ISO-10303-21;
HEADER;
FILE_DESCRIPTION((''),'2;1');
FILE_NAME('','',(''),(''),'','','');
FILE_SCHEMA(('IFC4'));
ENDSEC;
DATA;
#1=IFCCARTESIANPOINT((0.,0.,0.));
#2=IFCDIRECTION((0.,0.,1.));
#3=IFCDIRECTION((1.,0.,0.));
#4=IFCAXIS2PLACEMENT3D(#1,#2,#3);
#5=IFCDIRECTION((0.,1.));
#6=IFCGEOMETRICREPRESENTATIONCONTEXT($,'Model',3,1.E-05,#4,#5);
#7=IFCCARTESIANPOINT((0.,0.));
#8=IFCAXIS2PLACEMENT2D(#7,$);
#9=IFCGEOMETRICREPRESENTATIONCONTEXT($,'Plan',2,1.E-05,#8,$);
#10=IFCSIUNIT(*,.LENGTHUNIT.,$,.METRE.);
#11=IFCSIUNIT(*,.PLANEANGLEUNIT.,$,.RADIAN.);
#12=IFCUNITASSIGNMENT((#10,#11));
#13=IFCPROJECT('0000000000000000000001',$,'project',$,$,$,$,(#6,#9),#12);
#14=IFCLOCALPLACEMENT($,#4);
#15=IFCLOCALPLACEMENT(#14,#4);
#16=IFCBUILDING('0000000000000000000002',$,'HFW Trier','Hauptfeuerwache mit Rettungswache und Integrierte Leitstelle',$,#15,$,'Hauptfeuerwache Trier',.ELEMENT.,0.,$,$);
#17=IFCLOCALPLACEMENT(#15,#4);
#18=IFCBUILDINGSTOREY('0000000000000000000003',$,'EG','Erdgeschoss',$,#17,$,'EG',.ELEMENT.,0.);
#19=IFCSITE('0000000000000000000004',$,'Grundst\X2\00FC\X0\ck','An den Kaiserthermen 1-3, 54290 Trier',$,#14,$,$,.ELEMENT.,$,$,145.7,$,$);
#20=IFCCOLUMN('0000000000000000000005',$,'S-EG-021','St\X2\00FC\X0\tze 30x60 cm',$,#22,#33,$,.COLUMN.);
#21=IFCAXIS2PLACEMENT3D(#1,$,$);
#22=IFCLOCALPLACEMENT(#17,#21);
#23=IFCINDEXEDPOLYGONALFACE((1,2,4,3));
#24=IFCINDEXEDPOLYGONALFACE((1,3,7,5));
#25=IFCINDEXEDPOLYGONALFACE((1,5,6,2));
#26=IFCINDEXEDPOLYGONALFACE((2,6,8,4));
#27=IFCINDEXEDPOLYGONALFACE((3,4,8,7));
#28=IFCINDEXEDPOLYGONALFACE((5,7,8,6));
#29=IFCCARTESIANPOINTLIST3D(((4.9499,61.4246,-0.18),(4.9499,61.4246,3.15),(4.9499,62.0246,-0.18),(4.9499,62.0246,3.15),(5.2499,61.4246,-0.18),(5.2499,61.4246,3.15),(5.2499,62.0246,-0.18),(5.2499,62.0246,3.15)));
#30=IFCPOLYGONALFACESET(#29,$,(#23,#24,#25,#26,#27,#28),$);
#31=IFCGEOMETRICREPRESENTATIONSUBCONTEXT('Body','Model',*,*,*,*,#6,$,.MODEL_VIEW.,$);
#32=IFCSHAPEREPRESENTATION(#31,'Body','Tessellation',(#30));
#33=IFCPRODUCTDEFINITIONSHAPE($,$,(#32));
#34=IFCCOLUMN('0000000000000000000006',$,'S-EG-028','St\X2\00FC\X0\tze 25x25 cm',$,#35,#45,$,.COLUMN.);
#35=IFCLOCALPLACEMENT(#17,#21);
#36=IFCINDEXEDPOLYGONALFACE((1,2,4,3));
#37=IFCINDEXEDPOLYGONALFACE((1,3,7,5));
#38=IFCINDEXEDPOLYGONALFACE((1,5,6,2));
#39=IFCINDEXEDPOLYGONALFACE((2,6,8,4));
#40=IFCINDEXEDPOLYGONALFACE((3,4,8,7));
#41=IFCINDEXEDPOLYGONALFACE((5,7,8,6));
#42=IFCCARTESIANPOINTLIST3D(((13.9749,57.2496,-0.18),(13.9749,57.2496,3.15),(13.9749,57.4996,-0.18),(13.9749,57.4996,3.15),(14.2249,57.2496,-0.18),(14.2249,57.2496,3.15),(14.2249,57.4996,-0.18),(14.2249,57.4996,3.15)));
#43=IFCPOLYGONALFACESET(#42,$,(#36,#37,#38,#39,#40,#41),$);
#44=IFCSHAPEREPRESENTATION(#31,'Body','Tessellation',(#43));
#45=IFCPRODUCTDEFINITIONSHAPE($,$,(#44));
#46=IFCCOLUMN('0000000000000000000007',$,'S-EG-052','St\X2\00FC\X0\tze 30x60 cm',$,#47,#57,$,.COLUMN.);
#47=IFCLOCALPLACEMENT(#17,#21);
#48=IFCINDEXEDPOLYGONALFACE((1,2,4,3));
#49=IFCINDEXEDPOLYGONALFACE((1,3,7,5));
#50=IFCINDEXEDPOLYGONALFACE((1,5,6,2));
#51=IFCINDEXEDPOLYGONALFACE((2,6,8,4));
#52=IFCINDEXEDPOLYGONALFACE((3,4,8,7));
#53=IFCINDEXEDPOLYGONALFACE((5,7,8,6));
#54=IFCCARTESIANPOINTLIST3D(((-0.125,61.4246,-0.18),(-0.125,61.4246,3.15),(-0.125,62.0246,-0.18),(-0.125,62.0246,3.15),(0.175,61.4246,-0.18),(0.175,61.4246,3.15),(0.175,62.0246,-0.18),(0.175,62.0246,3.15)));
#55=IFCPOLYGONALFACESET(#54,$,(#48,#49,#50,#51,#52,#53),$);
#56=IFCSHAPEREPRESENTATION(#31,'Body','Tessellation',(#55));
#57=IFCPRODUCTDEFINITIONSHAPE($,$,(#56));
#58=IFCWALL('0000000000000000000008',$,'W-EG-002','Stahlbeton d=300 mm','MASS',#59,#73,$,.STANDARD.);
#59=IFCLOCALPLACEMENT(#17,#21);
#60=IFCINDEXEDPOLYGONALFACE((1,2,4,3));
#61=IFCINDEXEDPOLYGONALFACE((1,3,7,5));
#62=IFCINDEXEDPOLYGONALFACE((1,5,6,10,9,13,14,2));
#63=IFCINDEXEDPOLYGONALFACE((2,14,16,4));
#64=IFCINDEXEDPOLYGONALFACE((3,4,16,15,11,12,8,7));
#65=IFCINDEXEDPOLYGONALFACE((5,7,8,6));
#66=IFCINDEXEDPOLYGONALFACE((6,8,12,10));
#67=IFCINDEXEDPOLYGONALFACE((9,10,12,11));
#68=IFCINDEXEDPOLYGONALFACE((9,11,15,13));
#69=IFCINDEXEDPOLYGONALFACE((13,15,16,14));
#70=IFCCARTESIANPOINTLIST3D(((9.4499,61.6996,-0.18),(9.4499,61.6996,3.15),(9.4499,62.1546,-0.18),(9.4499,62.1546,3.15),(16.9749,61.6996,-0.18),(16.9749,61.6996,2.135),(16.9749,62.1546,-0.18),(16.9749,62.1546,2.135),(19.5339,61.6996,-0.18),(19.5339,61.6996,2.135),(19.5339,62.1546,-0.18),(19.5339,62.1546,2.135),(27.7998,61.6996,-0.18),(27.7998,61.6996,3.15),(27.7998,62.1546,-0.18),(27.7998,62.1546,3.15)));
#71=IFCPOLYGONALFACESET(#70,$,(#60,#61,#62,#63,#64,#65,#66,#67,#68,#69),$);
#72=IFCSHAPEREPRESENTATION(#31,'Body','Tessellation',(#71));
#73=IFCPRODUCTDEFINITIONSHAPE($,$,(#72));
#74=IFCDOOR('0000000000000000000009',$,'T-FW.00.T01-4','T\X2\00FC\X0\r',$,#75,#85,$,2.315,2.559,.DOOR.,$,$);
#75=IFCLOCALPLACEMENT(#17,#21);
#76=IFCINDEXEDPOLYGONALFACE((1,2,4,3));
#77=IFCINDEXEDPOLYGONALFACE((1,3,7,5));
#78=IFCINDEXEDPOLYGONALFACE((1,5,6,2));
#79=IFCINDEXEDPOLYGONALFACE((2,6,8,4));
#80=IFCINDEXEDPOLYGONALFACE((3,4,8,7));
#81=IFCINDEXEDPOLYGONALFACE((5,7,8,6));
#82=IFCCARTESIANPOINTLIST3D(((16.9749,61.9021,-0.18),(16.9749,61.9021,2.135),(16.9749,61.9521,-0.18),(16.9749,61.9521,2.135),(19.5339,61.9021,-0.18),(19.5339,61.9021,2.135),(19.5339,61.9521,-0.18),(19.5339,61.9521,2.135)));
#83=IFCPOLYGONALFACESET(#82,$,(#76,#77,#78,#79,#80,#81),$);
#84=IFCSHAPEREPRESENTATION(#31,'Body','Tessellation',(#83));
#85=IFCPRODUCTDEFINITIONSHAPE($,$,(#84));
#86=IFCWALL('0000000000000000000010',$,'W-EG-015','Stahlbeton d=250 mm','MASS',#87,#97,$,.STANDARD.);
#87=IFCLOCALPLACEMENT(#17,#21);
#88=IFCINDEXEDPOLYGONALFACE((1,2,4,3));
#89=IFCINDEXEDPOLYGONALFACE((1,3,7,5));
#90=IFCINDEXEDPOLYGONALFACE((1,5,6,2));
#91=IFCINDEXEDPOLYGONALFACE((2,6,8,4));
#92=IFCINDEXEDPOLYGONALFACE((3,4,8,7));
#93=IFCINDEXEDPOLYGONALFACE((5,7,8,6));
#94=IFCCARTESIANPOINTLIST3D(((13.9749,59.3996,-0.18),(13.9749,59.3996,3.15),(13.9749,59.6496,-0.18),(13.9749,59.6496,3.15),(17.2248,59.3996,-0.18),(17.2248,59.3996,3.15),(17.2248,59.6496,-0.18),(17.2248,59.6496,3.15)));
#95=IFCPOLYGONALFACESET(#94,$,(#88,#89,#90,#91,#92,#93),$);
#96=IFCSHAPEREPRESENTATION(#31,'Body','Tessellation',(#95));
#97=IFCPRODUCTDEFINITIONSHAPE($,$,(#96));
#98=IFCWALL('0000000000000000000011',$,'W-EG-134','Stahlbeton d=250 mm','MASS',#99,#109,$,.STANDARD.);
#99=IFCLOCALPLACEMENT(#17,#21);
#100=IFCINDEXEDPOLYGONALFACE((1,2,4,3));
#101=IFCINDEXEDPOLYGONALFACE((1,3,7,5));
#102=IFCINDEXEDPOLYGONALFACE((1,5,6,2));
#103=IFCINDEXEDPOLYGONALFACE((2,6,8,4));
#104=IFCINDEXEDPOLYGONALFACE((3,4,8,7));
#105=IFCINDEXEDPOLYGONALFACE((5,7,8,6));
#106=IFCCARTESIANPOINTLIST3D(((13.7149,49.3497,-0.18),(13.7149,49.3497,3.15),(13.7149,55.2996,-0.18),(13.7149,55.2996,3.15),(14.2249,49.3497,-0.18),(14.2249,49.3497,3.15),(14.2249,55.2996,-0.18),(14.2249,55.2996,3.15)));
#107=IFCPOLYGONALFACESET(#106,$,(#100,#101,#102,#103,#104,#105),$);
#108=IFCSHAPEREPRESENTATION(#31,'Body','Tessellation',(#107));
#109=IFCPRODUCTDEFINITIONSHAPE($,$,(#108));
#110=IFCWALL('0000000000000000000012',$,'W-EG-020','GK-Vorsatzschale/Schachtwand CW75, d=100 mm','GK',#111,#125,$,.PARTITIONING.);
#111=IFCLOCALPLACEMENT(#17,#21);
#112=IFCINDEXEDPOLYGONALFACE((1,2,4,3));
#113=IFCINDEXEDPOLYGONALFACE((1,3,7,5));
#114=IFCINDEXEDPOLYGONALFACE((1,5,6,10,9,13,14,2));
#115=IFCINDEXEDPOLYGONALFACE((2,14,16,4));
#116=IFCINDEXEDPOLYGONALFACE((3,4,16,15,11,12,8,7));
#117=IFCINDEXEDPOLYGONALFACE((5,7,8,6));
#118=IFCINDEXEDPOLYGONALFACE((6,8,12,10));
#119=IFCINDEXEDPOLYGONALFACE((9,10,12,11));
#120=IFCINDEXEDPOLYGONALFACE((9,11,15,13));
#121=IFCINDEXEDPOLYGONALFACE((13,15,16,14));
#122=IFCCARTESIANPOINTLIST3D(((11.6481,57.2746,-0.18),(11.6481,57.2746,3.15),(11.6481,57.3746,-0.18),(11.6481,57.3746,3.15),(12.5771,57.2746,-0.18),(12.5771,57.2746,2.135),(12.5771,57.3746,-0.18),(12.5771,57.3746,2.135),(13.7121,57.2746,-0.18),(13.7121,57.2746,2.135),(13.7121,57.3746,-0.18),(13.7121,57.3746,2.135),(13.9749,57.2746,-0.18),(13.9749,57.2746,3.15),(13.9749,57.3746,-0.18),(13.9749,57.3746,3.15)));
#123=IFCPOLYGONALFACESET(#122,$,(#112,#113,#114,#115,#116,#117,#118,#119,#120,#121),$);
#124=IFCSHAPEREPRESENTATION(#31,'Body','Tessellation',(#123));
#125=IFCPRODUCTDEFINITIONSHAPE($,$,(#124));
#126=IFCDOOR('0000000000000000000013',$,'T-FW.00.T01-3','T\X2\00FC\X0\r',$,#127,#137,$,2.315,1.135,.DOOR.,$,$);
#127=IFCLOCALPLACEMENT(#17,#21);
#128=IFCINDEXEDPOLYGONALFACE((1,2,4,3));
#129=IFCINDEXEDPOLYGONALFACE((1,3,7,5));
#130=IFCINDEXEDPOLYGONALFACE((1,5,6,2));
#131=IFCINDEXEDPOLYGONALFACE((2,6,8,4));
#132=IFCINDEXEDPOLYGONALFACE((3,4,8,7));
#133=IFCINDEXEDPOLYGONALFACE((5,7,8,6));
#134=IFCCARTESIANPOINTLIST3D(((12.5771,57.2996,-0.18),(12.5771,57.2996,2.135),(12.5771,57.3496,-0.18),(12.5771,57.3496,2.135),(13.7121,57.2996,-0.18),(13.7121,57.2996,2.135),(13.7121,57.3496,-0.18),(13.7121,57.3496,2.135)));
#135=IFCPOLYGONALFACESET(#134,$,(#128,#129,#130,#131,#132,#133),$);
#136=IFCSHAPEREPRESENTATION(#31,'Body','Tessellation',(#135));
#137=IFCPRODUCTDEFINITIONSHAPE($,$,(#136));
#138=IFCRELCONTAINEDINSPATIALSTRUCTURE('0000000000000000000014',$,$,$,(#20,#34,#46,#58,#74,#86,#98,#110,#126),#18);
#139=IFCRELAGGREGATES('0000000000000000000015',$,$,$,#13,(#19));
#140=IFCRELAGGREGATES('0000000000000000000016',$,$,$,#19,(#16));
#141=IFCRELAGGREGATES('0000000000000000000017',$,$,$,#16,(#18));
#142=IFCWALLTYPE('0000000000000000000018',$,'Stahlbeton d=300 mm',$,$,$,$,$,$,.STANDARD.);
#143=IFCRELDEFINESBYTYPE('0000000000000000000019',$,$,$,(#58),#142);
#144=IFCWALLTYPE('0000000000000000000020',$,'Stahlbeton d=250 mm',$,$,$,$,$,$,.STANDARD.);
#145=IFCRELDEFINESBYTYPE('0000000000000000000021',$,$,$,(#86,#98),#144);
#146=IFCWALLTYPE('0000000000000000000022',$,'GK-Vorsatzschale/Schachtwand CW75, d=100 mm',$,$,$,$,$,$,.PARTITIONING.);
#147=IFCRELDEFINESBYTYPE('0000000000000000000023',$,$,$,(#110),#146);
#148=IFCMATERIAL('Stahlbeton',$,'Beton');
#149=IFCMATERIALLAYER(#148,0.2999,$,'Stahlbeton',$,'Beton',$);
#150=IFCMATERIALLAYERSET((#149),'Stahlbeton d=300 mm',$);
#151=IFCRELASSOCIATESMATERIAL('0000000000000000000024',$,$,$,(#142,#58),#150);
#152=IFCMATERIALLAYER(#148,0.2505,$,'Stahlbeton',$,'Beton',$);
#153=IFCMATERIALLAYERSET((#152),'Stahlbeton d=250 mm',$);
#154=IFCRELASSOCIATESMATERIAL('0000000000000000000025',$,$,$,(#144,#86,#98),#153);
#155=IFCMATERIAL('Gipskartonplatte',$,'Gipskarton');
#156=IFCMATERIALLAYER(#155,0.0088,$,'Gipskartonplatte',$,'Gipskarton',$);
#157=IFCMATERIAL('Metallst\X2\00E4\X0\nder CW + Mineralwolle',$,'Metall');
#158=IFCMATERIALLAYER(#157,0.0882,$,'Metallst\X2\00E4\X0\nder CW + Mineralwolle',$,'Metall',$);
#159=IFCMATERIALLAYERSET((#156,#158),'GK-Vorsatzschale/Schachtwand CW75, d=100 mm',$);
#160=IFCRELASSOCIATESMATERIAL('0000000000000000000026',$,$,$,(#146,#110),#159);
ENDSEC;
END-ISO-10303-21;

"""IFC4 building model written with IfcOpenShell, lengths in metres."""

from ifc_helpers import new_model, si_unit, direction, frame, frame_2d, origin_with_axes, origin_2d, place, context, subcontext, project, spatial, rectangle, extrude, material, layer, layer_set, layer_usage, type_object, element, fill, save


model = new_model("IFC4")

# Units and contexts
model_context = context("Model", 3, precision=1e-05, world=origin_with_axes(), true_north=direction((0.0, 1.0)))
plan_context = context("Plan", 2, precision=1e-05, world=origin_2d())
body_context = subcontext(model_context, "Body", "Model", "MODEL_VIEW")
ifc_project = project(units=[si_unit("LENGTHUNIT", "METRE"), si_unit("PLANEANGLEUNIT", "RADIAN")], contexts=[model_context, plan_context])

# Site, building, storey
site_placement = place(None, origin_with_axes())
site = spatial("IfcSite", under=ifc_project, at=site_placement, Name="Grundstück", Description="An den Kaiserthermen 1-3, 54290 Trier", CompositionType="ELEMENT", RefElevation=145.7)
building_placement = place(site_placement, origin_with_axes())
building = spatial("IfcBuilding", under=site, at=building_placement, Name="HFW Trier", Description="Hauptfeuerwache mit Rettungswache und Integrierte Leitstelle", LongName="Hauptfeuerwache Trier", CompositionType="ELEMENT", ElevationOfRefHeight=0.0)
storey_placement = place(building_placement, origin_with_axes())
storey = spatial("IfcBuildingStorey", under=building, at=storey_placement, Name="EG", Description="Erdgeschoss", LongName="EG", CompositionType="ELEMENT", Elevation=0.0)

# Columns
column_1_placement = place(storey_placement, frame((4.9499, 61.7246, -0.18), z_axis=(0.0, 0.0, 1.0), x_axis=(1.0, 0.0, 0.0)))
element("IfcColumn", 1, at=column_1_placement, inside=storey, Name="S-EG-021", Description="Stütze 30x60 cm", PredefinedType="COLUMN", context=body_context, shape_type="SweptSolid", body=[
    extrude(rectangle(XDim=0.3, YDim=0.6, at=frame_2d((0.15, 0.0))), origin_with_axes(), (0.0, 0.0, 1.0), 3.33),
])
column_2_placement = place(storey_placement, frame((13.9749, 57.3746, -0.18), z_axis=(0.0, 0.0, 1.0), x_axis=(1.0, 0.0, 0.0)))
element("IfcColumn", 2, at=column_2_placement, inside=storey, Name="S-EG-028", Description="Stütze 25x25 cm", PredefinedType="COLUMN", context=body_context, shape_type="SweptSolid", body=[
    extrude(rectangle(XDim=0.25, YDim=0.25, at=frame_2d((0.125, 0.0))), origin_with_axes(), (0.0, 0.0, 1.0), 3.33),
])
column_3_placement = place(storey_placement, frame((-0.125, 61.7246, -0.18), z_axis=(0.0, 0.0, 1.0), x_axis=(1.0, 0.0, 0.0)))
element("IfcColumn", 3, at=column_3_placement, inside=storey, Name="S-EG-052", Description="Stütze 30x60 cm", PredefinedType="COLUMN", context=body_context, shape_type="SweptSolid", body=[
    extrude(rectangle(XDim=0.3, YDim=0.6, at=frame_2d((0.15, 0.0))), origin_with_axes(), (0.0, 0.0, 1.0), 3.33),
])

# Wall, opening, door
ifc_material_1 = material(Name="Stahlbeton", Category="Beton")
ifc_layer_1 = layer(ifc_material_1, 0.2999, Name="Stahlbeton", Category="Beton")
ifc_layer_set_1 = layer_set([ifc_layer_1], Name="Stahlbeton d=300 mm")
ifc_layer_usage_1 = layer_usage(ifc_layer_set_1, "AXIS2", "POSITIVE", -0.2275)
wall_type_1 = type_object("IfcWallType", Name="Stahlbeton d=300 mm", PredefinedType="STANDARD", material=ifc_layer_set_1)
wall_1_placement = place(storey_placement, frame((9.4499, 61.9271, -0.18), z_axis=(0.0, 0.0, 1.0), x_axis=(1.0, 0.0, 0.0)))
wall_1 = element("IfcWall", 4, at=wall_1_placement, inside=storey, type_object=wall_type_1, material=ifc_layer_usage_1, Name="W-EG-002", Description="Stahlbeton d=300 mm", ObjectType="MASS", PredefinedType="STANDARD", context=body_context, shape_type="SweptSolid", body=[
    extrude(rectangle(XDim=18.3499, YDim=0.455, at=frame_2d((9.175, 0.0))), origin_with_axes(), (0.0, 0.0, 1.0), 3.33),
])
opening_1_placement = place(wall_1_placement, frame((7.525, 0.0, 0.0), z_axis=(0.0, 0.0, 1.0), x_axis=(1.0, 0.0, 0.0)))
opening_1 = element("IfcOpeningElement", 5, at=opening_1_placement, cuts=wall_1, PredefinedType="OPENING", context=body_context, shape_type="SweptSolid", body=[
    extrude(rectangle(XDim=2.559, YDim=0.555, at=frame_2d((1.2795, 0.0))), origin_with_axes(), (0.0, 0.0, 1.0), 2.315),
])
door_1_placement = place(wall_1_placement, frame((7.525, 0.0, 0.0), z_axis=(0.0, 0.0, 1.0), x_axis=(1.0, 0.0, 0.0)))
door_1 = element("IfcDoor", 6, at=door_1_placement, inside=storey, Name="T-FW.00.T01-4", Description="Tür", OverallHeight=2.315, OverallWidth=2.559, PredefinedType="DOOR", context=body_context, shape_type="SweptSolid", body=[
    extrude(rectangle(XDim=2.559, YDim=0.05, at=frame_2d((1.2795, 0.0))), origin_with_axes(), (0.0, 0.0, 1.0), 2.315),
])
fill(opening_1, door_1)

# Walls
ifc_layer_2 = layer(ifc_material_1, 0.2505, Name="Stahlbeton", Category="Beton")
ifc_layer_set_2 = layer_set([ifc_layer_2], Name="Stahlbeton d=250 mm")
ifc_layer_usage_2 = layer_usage(ifc_layer_set_2, "AXIS2", "POSITIVE", -0.125)
wall_type_2 = type_object("IfcWallType", Name="Stahlbeton d=250 mm", PredefinedType="STANDARD", material=ifc_layer_set_2)
wall_2_placement = place(storey_placement, frame((13.9749, 59.5246, -0.18), z_axis=(0.0, 0.0, 1.0), x_axis=(1.0, 0.0, 0.0)))
element("IfcWall", 7, at=wall_2_placement, inside=storey, type_object=wall_type_2, material=ifc_layer_usage_2, Name="W-EG-015", Description="Stahlbeton d=250 mm", ObjectType="MASS", PredefinedType="STANDARD", context=body_context, shape_type="SweptSolid", body=[
    extrude(rectangle(XDim=3.2499, YDim=0.25, at=frame_2d((1.6249, 0.0))), origin_with_axes(), (0.0, 0.0, 1.0), 3.33),
])
ifc_layer_usage_3 = layer_usage(ifc_layer_set_2, "AXIS2", "POSITIVE", -0.255)
wall_3_placement = place(storey_placement, frame((13.9699, 55.2996, -0.18), z_axis=(0.0, 0.0, 1.0), x_axis=(0.0, -1.0, 0.0)))
element("IfcWall", 8, at=wall_3_placement, inside=storey, type_object=wall_type_2, material=ifc_layer_usage_3, Name="W-EG-134", Description="Stahlbeton d=250 mm", ObjectType="MASS", PredefinedType="STANDARD", context=body_context, shape_type="SweptSolid", body=[
    extrude(rectangle(XDim=5.9499, YDim=0.51, at=frame_2d((2.9749, 0.0))), origin_with_axes(), (0.0, 0.0, 1.0), 3.33),
])

# Wall, opening, door
ifc_material_2 = material(Name="Gipskartonplatte", Category="Gipskarton")
ifc_layer_3 = layer(ifc_material_2, 0.0088, Name="Gipskartonplatte", Category="Gipskarton")
ifc_material_3 = material(Name="Metallständer CW + Mineralwolle", Category="Metall")
ifc_layer_4 = layer(ifc_material_3, 0.0882, Name="Metallständer CW + Mineralwolle", Category="Metall")
ifc_layer_set_3 = layer_set([ifc_layer_3, ifc_layer_4], Name="GK-Vorsatzschale/Schachtwand CW75, d=100 mm")
ifc_layer_usage_4 = layer_usage(ifc_layer_set_3, "AXIS2", "POSITIVE", -0.05)
wall_type_3 = type_object("IfcWallType", Name="GK-Vorsatzschale/Schachtwand CW75, d=100 mm", PredefinedType="PARTITIONING", material=ifc_layer_set_3)
wall_4_placement = place(storey_placement, frame((11.6481, 57.3246, -0.18), z_axis=(0.0, 0.0, 1.0), x_axis=(1.0, 0.0, 0.0)))
wall_4 = element("IfcWall", 9, at=wall_4_placement, inside=storey, type_object=wall_type_3, material=ifc_layer_usage_4, Name="W-EG-020", Description="GK-Vorsatzschale/Schachtwand CW75, d=100 mm", ObjectType="GK", PredefinedType="PARTITIONING", context=body_context, shape_type="SweptSolid", body=[
    extrude(rectangle(XDim=2.3268, YDim=0.1001, at=frame_2d((1.1634, 0.0))), origin_with_axes(), (0.0, 0.0, 1.0), 3.33),
])
opening_2_placement = place(wall_4_placement, frame((0.929, 0.0, 0.0), z_axis=(0.0, 0.0, 1.0), x_axis=(1.0, 0.0, 0.0)))
opening_2 = element("IfcOpeningElement", 10, at=opening_2_placement, cuts=wall_4, PredefinedType="OPENING", context=body_context, shape_type="SweptSolid", body=[
    extrude(rectangle(XDim=1.135, YDim=0.2001, at=frame_2d((0.5675, 0.0))), origin_with_axes(), (0.0, 0.0, 1.0), 2.315),
])
door_2_placement = place(wall_4_placement, frame((0.929, 0.0, 0.0), z_axis=(0.0, 0.0, 1.0), x_axis=(1.0, 0.0, 0.0)))
door_2 = element("IfcDoor", 11, at=door_2_placement, inside=storey, Name="T-FW.00.T01-3", Description="Tür", OverallHeight=2.315, OverallWidth=1.135, PredefinedType="DOOR", context=body_context, shape_type="SweptSolid", body=[
    extrude(rectangle(XDim=1.135, YDim=0.05, at=frame_2d((0.5675, 0.0))), origin_with_axes(), (0.0, 0.0, 1.0), 2.315),
])
fill(opening_2, door_2)

save(model, "model.ifc")
